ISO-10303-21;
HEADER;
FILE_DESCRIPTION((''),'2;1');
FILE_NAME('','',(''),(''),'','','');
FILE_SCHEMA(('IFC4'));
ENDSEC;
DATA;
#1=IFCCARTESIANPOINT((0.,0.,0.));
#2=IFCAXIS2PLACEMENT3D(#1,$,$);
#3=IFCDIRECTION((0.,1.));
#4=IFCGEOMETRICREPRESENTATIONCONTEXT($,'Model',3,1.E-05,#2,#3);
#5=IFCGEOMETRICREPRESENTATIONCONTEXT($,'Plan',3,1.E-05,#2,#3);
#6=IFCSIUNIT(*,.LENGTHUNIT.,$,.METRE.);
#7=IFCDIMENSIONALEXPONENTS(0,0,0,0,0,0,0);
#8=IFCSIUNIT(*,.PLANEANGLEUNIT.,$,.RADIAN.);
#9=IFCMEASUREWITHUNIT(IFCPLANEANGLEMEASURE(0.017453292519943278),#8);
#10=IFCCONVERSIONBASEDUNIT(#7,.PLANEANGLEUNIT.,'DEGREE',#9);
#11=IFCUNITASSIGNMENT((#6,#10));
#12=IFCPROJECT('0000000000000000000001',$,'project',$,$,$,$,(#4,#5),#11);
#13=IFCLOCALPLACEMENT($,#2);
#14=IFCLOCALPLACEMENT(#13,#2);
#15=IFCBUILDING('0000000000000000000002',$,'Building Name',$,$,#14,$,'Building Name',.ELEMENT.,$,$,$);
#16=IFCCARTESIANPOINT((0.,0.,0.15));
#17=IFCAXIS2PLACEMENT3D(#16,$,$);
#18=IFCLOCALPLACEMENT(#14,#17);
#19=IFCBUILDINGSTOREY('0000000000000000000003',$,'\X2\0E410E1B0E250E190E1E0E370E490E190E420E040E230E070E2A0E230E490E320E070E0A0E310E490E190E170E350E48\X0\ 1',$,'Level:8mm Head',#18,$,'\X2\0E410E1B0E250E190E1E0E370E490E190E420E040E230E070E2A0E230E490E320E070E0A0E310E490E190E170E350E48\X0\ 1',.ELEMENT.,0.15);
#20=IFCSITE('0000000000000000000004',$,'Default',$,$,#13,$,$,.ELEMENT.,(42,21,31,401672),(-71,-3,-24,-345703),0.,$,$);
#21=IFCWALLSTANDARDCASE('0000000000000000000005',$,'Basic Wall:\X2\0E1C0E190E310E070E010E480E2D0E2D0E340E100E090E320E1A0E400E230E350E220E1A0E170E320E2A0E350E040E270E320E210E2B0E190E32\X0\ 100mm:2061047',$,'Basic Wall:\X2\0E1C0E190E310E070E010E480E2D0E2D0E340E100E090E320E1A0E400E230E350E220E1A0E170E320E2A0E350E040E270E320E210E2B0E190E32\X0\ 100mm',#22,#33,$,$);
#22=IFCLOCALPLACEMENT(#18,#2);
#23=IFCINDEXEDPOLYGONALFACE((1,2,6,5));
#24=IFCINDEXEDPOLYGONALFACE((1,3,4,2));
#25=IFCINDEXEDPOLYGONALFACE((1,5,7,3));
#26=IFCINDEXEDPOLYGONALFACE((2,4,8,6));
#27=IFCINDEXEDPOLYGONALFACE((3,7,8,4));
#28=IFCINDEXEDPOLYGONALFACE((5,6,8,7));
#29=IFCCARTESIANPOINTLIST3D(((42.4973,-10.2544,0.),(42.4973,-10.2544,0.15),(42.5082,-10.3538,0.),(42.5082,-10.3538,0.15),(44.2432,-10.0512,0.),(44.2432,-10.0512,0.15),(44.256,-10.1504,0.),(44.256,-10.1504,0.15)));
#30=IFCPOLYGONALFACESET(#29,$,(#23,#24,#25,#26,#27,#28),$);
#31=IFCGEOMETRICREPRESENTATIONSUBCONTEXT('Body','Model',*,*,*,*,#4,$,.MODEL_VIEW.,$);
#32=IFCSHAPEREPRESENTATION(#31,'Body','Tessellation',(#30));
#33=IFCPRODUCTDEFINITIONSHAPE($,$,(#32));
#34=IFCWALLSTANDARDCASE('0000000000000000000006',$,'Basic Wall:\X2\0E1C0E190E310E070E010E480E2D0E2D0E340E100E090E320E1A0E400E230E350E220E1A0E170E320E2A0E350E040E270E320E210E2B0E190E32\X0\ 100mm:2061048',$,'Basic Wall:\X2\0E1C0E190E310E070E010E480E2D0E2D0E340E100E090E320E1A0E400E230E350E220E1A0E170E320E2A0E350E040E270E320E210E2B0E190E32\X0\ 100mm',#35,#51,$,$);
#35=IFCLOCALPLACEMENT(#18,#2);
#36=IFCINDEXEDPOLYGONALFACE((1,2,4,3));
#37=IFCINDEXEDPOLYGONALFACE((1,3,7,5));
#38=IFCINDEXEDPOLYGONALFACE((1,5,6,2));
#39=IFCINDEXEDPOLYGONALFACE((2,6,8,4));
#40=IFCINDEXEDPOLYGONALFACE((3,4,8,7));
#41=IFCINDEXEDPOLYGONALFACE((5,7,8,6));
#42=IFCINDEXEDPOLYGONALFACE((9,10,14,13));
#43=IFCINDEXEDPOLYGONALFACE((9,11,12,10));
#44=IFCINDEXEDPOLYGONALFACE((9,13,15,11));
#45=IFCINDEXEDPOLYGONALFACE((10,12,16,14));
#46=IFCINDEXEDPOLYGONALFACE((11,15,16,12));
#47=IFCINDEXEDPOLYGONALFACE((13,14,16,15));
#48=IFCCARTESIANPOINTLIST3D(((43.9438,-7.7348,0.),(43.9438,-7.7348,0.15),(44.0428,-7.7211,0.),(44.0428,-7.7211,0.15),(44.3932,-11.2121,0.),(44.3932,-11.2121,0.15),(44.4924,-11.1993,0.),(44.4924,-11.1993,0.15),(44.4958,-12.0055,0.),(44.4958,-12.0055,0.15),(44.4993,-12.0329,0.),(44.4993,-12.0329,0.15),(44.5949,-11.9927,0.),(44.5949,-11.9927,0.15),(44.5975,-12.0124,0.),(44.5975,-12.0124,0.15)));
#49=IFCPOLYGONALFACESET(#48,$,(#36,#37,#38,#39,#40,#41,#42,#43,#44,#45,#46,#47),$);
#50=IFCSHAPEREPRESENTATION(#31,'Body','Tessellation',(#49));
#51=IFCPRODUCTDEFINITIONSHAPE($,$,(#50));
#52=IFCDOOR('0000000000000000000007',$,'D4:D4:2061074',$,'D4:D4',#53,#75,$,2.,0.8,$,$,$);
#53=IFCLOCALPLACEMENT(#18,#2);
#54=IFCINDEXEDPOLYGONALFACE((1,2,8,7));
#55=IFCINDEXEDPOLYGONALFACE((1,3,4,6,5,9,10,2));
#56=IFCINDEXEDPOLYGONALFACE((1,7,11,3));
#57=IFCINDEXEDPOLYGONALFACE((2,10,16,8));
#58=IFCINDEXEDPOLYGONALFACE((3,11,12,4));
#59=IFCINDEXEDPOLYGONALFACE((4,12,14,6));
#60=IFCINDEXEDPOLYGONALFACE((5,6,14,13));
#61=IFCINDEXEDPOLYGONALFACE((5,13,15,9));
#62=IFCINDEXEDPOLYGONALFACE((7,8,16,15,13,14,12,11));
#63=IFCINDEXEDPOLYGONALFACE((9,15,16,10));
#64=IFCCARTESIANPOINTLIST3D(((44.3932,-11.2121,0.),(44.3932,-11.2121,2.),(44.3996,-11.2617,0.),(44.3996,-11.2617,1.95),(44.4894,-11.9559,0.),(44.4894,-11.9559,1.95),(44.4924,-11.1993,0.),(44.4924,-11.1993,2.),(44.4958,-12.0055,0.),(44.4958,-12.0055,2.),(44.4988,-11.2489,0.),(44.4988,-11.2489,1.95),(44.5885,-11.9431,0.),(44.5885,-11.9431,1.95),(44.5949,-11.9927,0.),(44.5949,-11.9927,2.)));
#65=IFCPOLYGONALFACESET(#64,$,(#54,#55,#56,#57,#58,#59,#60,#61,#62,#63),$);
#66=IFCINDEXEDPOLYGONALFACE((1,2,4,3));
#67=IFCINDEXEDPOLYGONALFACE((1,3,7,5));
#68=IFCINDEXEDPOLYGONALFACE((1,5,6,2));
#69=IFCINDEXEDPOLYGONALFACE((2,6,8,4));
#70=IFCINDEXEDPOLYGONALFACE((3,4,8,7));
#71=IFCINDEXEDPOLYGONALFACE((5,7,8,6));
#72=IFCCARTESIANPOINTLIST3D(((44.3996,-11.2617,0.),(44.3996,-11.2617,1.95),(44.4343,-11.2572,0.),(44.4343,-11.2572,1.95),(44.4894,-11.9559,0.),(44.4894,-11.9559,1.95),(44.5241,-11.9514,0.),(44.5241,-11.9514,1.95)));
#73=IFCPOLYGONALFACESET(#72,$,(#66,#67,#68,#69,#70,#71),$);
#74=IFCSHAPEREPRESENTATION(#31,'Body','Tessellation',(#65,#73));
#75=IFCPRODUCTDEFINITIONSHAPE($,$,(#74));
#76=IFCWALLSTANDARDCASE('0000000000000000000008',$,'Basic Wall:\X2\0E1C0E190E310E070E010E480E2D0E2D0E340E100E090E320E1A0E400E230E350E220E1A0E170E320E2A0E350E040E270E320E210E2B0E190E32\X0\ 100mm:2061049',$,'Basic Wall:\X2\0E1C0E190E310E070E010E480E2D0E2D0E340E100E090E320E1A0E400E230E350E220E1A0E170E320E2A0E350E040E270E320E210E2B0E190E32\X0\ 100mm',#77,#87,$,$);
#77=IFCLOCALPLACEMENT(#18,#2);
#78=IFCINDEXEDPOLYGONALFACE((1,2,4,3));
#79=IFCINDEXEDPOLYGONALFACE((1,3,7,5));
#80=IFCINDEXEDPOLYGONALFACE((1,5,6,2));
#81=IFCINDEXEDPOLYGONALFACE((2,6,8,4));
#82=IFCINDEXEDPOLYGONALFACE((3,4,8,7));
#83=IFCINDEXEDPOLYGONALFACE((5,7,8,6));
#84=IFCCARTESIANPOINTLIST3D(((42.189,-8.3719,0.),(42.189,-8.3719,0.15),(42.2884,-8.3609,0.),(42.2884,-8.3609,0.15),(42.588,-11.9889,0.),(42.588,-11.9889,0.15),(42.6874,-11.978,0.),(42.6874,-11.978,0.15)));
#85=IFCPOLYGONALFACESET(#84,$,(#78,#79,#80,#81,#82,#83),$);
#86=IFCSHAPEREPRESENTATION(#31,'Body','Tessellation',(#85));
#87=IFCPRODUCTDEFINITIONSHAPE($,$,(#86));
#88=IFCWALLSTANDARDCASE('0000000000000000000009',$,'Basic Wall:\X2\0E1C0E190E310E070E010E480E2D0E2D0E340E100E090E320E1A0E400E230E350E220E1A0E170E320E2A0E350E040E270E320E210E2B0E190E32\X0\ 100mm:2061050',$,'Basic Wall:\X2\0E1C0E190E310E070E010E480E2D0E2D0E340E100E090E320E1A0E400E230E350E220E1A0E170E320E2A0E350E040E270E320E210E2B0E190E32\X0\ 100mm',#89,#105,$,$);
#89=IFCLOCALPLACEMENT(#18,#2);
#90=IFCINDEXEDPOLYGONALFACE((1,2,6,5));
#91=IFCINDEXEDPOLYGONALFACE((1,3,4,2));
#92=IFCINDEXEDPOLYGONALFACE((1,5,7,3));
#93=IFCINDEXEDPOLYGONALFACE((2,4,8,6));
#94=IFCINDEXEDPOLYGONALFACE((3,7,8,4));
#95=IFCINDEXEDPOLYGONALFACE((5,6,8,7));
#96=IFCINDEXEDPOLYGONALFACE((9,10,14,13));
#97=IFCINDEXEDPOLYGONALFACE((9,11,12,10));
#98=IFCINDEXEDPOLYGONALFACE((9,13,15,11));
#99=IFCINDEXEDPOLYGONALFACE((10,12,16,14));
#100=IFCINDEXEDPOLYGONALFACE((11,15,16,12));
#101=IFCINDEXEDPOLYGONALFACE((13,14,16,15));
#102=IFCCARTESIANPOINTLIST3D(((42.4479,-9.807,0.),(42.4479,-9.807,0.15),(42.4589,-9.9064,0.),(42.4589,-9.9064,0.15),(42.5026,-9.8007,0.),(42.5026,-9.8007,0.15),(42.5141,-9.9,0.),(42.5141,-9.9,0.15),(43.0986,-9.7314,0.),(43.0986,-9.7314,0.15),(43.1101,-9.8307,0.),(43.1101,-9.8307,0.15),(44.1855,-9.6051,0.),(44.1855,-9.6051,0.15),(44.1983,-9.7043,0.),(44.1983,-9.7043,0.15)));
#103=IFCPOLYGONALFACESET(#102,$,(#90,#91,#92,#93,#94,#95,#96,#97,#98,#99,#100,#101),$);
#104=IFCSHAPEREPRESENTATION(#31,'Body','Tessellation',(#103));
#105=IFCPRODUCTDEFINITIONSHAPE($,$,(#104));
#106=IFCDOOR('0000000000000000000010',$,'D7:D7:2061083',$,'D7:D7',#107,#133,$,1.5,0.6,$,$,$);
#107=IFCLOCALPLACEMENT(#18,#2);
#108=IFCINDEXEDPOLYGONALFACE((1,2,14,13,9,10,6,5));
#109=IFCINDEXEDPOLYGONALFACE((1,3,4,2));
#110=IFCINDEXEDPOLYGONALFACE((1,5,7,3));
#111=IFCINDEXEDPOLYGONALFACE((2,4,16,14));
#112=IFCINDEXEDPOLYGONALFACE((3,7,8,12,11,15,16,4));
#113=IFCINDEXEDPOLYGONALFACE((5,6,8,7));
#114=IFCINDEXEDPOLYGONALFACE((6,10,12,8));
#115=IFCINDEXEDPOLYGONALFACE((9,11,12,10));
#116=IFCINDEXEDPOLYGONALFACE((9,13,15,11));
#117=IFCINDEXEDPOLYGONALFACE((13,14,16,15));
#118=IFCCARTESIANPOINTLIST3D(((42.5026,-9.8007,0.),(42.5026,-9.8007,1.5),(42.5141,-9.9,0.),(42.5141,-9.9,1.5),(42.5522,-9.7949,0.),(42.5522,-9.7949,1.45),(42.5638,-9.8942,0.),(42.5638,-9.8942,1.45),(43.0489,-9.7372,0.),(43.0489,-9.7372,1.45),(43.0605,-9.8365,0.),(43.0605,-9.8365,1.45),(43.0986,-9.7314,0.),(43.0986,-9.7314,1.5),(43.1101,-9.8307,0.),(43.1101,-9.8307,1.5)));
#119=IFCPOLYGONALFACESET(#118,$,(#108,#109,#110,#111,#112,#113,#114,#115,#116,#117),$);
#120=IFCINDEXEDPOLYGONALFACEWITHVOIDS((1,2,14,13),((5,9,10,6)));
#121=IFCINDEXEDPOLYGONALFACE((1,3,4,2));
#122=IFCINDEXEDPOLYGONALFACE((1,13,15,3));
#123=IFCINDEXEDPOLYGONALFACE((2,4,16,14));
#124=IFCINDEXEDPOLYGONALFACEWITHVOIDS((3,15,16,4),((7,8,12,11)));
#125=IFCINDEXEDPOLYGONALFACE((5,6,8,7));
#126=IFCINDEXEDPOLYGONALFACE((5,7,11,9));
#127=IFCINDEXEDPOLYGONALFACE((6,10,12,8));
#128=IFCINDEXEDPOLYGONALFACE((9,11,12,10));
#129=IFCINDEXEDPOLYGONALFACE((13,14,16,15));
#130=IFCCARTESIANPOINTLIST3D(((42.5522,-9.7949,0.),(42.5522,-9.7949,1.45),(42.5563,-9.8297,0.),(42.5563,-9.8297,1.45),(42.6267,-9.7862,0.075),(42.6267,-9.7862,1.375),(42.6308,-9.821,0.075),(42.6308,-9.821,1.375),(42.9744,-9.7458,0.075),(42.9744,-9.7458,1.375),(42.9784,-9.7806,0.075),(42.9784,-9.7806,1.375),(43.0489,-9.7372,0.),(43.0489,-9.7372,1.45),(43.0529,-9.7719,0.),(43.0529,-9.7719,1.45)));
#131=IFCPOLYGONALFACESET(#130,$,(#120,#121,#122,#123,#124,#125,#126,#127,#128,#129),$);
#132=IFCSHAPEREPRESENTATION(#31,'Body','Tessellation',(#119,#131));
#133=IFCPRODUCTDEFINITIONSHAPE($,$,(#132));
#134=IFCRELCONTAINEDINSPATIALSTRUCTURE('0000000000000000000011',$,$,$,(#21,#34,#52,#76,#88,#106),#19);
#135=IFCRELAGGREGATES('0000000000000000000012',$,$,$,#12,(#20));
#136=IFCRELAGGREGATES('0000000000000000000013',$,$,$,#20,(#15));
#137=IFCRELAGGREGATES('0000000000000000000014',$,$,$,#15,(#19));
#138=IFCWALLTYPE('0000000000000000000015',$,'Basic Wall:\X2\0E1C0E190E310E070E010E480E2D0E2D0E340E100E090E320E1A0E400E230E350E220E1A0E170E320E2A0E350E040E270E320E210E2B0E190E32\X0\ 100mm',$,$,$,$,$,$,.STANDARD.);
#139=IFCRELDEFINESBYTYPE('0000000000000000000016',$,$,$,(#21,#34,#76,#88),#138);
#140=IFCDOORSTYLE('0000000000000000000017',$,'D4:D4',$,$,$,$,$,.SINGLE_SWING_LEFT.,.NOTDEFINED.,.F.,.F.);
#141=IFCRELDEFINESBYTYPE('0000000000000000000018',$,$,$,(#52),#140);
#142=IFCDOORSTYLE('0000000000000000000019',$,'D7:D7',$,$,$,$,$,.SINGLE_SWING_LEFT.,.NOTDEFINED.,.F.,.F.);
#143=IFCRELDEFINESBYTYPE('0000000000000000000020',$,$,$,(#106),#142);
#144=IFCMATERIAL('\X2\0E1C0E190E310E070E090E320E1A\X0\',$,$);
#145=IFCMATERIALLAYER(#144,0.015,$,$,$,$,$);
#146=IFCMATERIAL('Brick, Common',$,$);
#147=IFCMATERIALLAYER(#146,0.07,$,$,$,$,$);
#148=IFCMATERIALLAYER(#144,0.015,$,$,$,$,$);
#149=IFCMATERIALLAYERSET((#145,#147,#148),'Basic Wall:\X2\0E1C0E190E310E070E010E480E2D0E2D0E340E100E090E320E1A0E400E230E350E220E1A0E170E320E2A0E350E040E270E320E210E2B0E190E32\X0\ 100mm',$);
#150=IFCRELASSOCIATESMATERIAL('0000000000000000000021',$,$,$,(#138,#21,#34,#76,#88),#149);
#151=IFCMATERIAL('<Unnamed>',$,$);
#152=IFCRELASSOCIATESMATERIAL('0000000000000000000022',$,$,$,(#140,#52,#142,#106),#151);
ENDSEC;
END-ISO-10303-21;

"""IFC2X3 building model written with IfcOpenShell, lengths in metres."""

from ifc_helpers import new_model, entity, si_unit, converted_unit, direction, frame, frame_2d, origin, origin_2d_with_axis, place, context, subcontext, project, spatial, polyline, rectangle, outline, extrude, clip, halfspace, source, transform, mapped, material, layer, layer_set, layer_usage, type_object, type_shapes, element, fill, save


model = new_model("IFC2X3")

# Units and contexts
model_context = context("Model", 3, precision=1e-05, world=origin(), true_north=direction((0.0, 1.0)))
plan_context = context("Plan", 3, precision=1e-05, world=origin(), true_north=direction((0.0, 1.0)))
body_context = subcontext(model_context, "Body", "Model", "MODEL_VIEW")
ifc_project = project(units=[si_unit("LENGTHUNIT", "METRE"), converted_unit("PLANEANGLEUNIT", "DEGREE", entity("IfcPlaneAngleMeasure", 0.017453292519943278), si_unit("PLANEANGLEUNIT", "RADIAN"), dimensions=[0, 0, 0, 0, 0, 0, 0])], contexts=[model_context, plan_context])

# Site, building, storey
site_placement = place(None, origin())
site = spatial("IfcSite", under=ifc_project, at=site_placement, Name="Default", CompositionType="ELEMENT", RefLatitude=(42, 21, 31, 401672), RefLongitude=(-71, -3, -24, -345703), RefElevation=0.0)
building_placement = place(site_placement, origin())
building = spatial("IfcBuilding", under=site, at=building_placement, Name="Building Name", LongName="Building Name", CompositionType="ELEMENT")
storey_placement = place(building_placement, frame((0.0, 0.0, 0.15)))
storey = spatial("IfcBuildingStorey", under=building, at=storey_placement, Name="แปลนพื้นโครงสร้างชั้นที่ 1", ObjectType="Level:8mm Head", LongName="แปลนพื้นโครงสร้างชั้นที่ 1", CompositionType="ELEMENT", Elevation=0.15)

# Shared definitions
ifc_material_1 = material(Name="ผนังฉาบ")
ifc_layer_1 = layer(ifc_material_1, 0.015)
ifc_material_2 = material(Name="Brick, Common")
ifc_layer_2 = layer(ifc_material_2, 0.07)
ifc_layer_3 = layer(ifc_material_1, 0.015)
ifc_layer_set = layer_set([ifc_layer_1, ifc_layer_2, ifc_layer_3], Name="Basic Wall:ผนังก่ออิฐฉาบเรียบทาสีความหนา 100mm")
wall_type = type_object("IfcWallType", Name="Basic Wall:ผนังก่ออิฐฉาบเรียบทาสีความหนา 100mm", PredefinedType="STANDARD", material=ifc_layer_set)

# Wall
ifc_layer_usage_1 = layer_usage(ifc_layer_set, "AXIS2", "POSITIVE", -0.05)
wall_1_placement = place(storey_placement, frame((42.5024, -10.3041, 0.0), z_axis=(0.0, 0.0, 1.0), x_axis=(0.993294, 0.115614, 0.0)))
element("IfcWallStandardCase", 1, at=wall_1_placement, inside=storey, type_object=wall_type, material=ifc_layer_usage_1, Name="Basic Wall:ผนังก่ออิฐฉาบเรียบทาสีความหนา 100mm:2061047", ObjectType="Basic Wall:ผนังก่ออิฐฉาบเรียบทาสีความหนา 100mm", context=body_context, shape_type="Clipping", body=[
    clip(extrude(outline(polyline([(1.7596, -0.05), (1.7583, 0.05), (0.0006, 0.05), (0.0, -0.05), (1.7596, -0.05)])), origin(), (0.0, 0.0, 1.0), 0.15), halfspace(origin(), True)),
])

# Wall, opening, door
ifc_layer_usage_2 = layer_usage(ifc_layer_set, "AXIS2", "NEGATIVE", 0.05)
wall_2_placement = place(storey_placement, frame((43.9933, -7.7275, 0.0), z_axis=(0.0, 0.0, 1.0), x_axis=(0.128183, -0.991751, 0.0)))
wall_2 = element("IfcWallStandardCase", 2, at=wall_2_placement, inside=storey, type_object=wall_type, material=ifc_layer_usage_2, Name="Basic Wall:ผนังก่ออิฐฉาบเรียบทาสีความหนา 100mm:2061048", ObjectType="Basic Wall:ผนังก่ออิฐฉาบเรียบทาสีความหนา 100mm", context=body_context, shape_type="Clipping", body=[
    clip(extrude(outline(polyline([(0.0009, -0.05), (1.8867, -0.05), (1.9867, -0.05), (2.3365, -0.05), (2.4365, -0.05), (4.3347, -0.05), (4.327, 0.05), (0.0, 0.05), (0.0009, -0.05)])), origin(), (0.0, 0.0, 1.0), 0.15), halfspace(origin(), True)),
])
opening_1_placement = place(wall_2_placement, frame((4.3071, 0.05, 0.0)))
opening_1 = element("IfcOpeningElement", 3, at=opening_1_placement, cuts=wall_2, ObjectType="Opening", context=body_context, shape_type="SweptSolid", body=[
    extrude(rectangle(XDim=2.0, YDim=0.8, at=frame_2d((1.0, 0.4), x_axis=(1.0, 0.0))), frame((0.0, 0.0, 0.0), z_axis=(0.0, -1.0, 0.0), x_axis=(0.0, 0.0, 1.0)), (0.0, 0.0, 1.0), 0.1),
])
ifc_material_3 = material(Name="<Unnamed>")
door_style_1 = type_object("IfcDoorStyle", Name="D4:D4", ConstructionType="NOTDEFINED", OperationType="SINGLE_SWING_LEFT", ParameterTakesPrecedence=False, Sizeable=False, material=ifc_material_3)
shared_shape_1 = source(origin(), body_context, "Body", "SweptSolid", [
    extrude(outline(polyline([(-0.9875, -0.35), (-0.9875, -0.4), (1.0125, -0.4), (1.0125, 0.4), (-0.9875, 0.4), (-0.9875, 0.35), (0.9625, 0.35), (0.9625, -0.35), (-0.9875, -0.35)])), frame((0.4, 0.0, 0.9875), z_axis=(0.0, -1.0, 0.0), x_axis=(0.0, 0.0, 1.0)), (0.0, 0.0, -1.0), 0.1),
    extrude(rectangle(XDim=0.7, YDim=0.035, at=origin_2d_with_axis()), frame((0.4, 0.0825, 0.0), z_axis=(0.0, 0.0, 1.0), x_axis=(-1.0, 0.0, 0.0)), (0.0, 0.0, 1.0), 1.95),
])
type_shapes(door_style_1, [shared_shape_1])
door_1_placement = place(opening_1_placement, frame((0.0, 0.0, 0.0), z_axis=(0.0, 0.0, 1.0), x_axis=(-1.0, 0.0, 0.0)))
door_1 = element("IfcDoor", 4, at=door_1_placement, inside=storey, type_object=door_style_1, material=ifc_material_3, Name="D4:D4:2061074", ObjectType="D4:D4", OverallHeight=2.0, OverallWidth=0.8, context=body_context, shape_type="MappedRepresentation", body=[
    mapped(shared_shape_1, transform((0.0, 0.0, 0.0), scale=1.0)),
])
fill(opening_1, door_1)

# Wall
ifc_layer_usage_3 = layer_usage(ifc_layer_set, "AXIS2", "NEGATIVE", 0.05)
wall_3_placement = place(storey_placement, frame((42.6377, -11.9835, 0.0), z_axis=(0.0, 0.0, 1.0), x_axis=(-0.10965, 0.99397, 0.0)))
element("IfcWallStandardCase", 5, at=wall_3_placement, inside=storey, type_object=wall_type, material=ifc_layer_usage_3, Name="Basic Wall:ผนังก่ออิฐฉาบเรียบทาสีความหนา 100mm:2061049", ObjectType="Basic Wall:ผนังก่ออิฐฉาบเรียบทาสีความหนา 100mm", context=body_context, shape_type="Clipping", body=[
    clip(extrude(rectangle(XDim=3.639, YDim=0.1, at=frame_2d((1.8195, 0.0), x_axis=(-1.0, 0.0))), origin(), (0.0, 0.0, 1.0), 0.15), halfspace(origin(), True)),
])

# Wall, opening, door
ifc_layer_usage_4 = layer_usage(ifc_layer_set, "AXIS2", "NEGATIVE", 0.05)
wall_4_placement = place(storey_placement, frame((44.1926, -9.6546, 0.0), z_axis=(0.0, 0.0, 1.0), x_axis=(-0.993315, -0.115438, 0.0)))
wall_4 = element("IfcWallStandardCase", 6, at=wall_4_placement, inside=storey, type_object=wall_type, material=ifc_layer_usage_4, Name="Basic Wall:ผนังก่ออิฐฉาบเรียบทาสีความหนา 100mm:2061050", ObjectType="Basic Wall:ผนังก่ออิฐฉาบเรียบทาสีความหนา 100mm", context=body_context, shape_type="Clipping", body=[
    clip(extrude(outline(polyline([(0.0013, -0.05), (1.7506, -0.05), (1.7512, 0.05), (0.0, 0.05), (0.0013, -0.05)])), origin(), (0.0, 0.0, 1.0), 0.15), halfspace(origin(), True)),
])
opening_2_placement = place(wall_4_placement, frame((1.6955, 0.05, 0.0)))
opening_2 = element("IfcOpeningElement", 7, at=opening_2_placement, cuts=wall_4, ObjectType="Opening", context=body_context, shape_type="SweptSolid", body=[
    extrude(rectangle(XDim=1.5, YDim=0.6, at=frame_2d((0.75, 0.3), x_axis=(1.0, 0.0))), frame((0.0, 0.0, 0.0), z_axis=(0.0, -1.0, 0.0), x_axis=(0.0, 0.0, 1.0)), (0.0, 0.0, 1.0), 0.1),
])
door_style_2 = type_object("IfcDoorStyle", Name="D7:D7", ConstructionType="NOTDEFINED", OperationType="SINGLE_SWING_LEFT", ParameterTakesPrecedence=False, Sizeable=False, material=ifc_material_3)
shared_shape_2 = source(origin(), body_context, "Body", "SweptSolid", [
    extrude(outline(polyline([(-0.7375, -0.25), (-0.7375, -0.3), (0.7625, -0.3), (0.7625, 0.3), (-0.7375, 0.3), (-0.7375, 0.25), (0.7125, 0.25), (0.7125, -0.25), (-0.7375, -0.25)])), frame((0.3, 0.0, 0.7375), z_axis=(0.0, -1.0, 0.0), x_axis=(0.0, 0.0, 1.0)), (0.0, 0.0, -1.0), 0.1),
    extrude(outline(polyline([(-0.725, -0.25), (0.725, -0.25), (0.725, 0.25), (-0.725, 0.25), (-0.725, -0.25)]), holes=[polyline([(0.65, -0.175), (-0.65, -0.175), (-0.65, 0.175), (0.65, 0.175), (0.65, -0.175)])]), frame((0.3, 0.065, 0.725), z_axis=(0.0, 1.0, 0.0), x_axis=(0.0, 0.0, 1.0)), (0.0, 0.0, 1.0), 0.035),
])
type_shapes(door_style_2, [shared_shape_2])
door_2_placement = place(opening_2_placement, frame((0.0, 0.0, 0.0), z_axis=(0.0, 0.0, 1.0), x_axis=(-1.0, 0.0, 0.0)))
door_2 = element("IfcDoor", 8, at=door_2_placement, inside=storey, type_object=door_style_2, material=ifc_material_3, Name="D7:D7:2061083", ObjectType="D7:D7", OverallHeight=1.5, OverallWidth=0.6, context=body_context, shape_type="MappedRepresentation", body=[
    mapped(shared_shape_2, transform((0.0, 0.0, 0.0), scale=1.0)),
])
fill(opening_2, door_2)

save(model, "model.ifc")
